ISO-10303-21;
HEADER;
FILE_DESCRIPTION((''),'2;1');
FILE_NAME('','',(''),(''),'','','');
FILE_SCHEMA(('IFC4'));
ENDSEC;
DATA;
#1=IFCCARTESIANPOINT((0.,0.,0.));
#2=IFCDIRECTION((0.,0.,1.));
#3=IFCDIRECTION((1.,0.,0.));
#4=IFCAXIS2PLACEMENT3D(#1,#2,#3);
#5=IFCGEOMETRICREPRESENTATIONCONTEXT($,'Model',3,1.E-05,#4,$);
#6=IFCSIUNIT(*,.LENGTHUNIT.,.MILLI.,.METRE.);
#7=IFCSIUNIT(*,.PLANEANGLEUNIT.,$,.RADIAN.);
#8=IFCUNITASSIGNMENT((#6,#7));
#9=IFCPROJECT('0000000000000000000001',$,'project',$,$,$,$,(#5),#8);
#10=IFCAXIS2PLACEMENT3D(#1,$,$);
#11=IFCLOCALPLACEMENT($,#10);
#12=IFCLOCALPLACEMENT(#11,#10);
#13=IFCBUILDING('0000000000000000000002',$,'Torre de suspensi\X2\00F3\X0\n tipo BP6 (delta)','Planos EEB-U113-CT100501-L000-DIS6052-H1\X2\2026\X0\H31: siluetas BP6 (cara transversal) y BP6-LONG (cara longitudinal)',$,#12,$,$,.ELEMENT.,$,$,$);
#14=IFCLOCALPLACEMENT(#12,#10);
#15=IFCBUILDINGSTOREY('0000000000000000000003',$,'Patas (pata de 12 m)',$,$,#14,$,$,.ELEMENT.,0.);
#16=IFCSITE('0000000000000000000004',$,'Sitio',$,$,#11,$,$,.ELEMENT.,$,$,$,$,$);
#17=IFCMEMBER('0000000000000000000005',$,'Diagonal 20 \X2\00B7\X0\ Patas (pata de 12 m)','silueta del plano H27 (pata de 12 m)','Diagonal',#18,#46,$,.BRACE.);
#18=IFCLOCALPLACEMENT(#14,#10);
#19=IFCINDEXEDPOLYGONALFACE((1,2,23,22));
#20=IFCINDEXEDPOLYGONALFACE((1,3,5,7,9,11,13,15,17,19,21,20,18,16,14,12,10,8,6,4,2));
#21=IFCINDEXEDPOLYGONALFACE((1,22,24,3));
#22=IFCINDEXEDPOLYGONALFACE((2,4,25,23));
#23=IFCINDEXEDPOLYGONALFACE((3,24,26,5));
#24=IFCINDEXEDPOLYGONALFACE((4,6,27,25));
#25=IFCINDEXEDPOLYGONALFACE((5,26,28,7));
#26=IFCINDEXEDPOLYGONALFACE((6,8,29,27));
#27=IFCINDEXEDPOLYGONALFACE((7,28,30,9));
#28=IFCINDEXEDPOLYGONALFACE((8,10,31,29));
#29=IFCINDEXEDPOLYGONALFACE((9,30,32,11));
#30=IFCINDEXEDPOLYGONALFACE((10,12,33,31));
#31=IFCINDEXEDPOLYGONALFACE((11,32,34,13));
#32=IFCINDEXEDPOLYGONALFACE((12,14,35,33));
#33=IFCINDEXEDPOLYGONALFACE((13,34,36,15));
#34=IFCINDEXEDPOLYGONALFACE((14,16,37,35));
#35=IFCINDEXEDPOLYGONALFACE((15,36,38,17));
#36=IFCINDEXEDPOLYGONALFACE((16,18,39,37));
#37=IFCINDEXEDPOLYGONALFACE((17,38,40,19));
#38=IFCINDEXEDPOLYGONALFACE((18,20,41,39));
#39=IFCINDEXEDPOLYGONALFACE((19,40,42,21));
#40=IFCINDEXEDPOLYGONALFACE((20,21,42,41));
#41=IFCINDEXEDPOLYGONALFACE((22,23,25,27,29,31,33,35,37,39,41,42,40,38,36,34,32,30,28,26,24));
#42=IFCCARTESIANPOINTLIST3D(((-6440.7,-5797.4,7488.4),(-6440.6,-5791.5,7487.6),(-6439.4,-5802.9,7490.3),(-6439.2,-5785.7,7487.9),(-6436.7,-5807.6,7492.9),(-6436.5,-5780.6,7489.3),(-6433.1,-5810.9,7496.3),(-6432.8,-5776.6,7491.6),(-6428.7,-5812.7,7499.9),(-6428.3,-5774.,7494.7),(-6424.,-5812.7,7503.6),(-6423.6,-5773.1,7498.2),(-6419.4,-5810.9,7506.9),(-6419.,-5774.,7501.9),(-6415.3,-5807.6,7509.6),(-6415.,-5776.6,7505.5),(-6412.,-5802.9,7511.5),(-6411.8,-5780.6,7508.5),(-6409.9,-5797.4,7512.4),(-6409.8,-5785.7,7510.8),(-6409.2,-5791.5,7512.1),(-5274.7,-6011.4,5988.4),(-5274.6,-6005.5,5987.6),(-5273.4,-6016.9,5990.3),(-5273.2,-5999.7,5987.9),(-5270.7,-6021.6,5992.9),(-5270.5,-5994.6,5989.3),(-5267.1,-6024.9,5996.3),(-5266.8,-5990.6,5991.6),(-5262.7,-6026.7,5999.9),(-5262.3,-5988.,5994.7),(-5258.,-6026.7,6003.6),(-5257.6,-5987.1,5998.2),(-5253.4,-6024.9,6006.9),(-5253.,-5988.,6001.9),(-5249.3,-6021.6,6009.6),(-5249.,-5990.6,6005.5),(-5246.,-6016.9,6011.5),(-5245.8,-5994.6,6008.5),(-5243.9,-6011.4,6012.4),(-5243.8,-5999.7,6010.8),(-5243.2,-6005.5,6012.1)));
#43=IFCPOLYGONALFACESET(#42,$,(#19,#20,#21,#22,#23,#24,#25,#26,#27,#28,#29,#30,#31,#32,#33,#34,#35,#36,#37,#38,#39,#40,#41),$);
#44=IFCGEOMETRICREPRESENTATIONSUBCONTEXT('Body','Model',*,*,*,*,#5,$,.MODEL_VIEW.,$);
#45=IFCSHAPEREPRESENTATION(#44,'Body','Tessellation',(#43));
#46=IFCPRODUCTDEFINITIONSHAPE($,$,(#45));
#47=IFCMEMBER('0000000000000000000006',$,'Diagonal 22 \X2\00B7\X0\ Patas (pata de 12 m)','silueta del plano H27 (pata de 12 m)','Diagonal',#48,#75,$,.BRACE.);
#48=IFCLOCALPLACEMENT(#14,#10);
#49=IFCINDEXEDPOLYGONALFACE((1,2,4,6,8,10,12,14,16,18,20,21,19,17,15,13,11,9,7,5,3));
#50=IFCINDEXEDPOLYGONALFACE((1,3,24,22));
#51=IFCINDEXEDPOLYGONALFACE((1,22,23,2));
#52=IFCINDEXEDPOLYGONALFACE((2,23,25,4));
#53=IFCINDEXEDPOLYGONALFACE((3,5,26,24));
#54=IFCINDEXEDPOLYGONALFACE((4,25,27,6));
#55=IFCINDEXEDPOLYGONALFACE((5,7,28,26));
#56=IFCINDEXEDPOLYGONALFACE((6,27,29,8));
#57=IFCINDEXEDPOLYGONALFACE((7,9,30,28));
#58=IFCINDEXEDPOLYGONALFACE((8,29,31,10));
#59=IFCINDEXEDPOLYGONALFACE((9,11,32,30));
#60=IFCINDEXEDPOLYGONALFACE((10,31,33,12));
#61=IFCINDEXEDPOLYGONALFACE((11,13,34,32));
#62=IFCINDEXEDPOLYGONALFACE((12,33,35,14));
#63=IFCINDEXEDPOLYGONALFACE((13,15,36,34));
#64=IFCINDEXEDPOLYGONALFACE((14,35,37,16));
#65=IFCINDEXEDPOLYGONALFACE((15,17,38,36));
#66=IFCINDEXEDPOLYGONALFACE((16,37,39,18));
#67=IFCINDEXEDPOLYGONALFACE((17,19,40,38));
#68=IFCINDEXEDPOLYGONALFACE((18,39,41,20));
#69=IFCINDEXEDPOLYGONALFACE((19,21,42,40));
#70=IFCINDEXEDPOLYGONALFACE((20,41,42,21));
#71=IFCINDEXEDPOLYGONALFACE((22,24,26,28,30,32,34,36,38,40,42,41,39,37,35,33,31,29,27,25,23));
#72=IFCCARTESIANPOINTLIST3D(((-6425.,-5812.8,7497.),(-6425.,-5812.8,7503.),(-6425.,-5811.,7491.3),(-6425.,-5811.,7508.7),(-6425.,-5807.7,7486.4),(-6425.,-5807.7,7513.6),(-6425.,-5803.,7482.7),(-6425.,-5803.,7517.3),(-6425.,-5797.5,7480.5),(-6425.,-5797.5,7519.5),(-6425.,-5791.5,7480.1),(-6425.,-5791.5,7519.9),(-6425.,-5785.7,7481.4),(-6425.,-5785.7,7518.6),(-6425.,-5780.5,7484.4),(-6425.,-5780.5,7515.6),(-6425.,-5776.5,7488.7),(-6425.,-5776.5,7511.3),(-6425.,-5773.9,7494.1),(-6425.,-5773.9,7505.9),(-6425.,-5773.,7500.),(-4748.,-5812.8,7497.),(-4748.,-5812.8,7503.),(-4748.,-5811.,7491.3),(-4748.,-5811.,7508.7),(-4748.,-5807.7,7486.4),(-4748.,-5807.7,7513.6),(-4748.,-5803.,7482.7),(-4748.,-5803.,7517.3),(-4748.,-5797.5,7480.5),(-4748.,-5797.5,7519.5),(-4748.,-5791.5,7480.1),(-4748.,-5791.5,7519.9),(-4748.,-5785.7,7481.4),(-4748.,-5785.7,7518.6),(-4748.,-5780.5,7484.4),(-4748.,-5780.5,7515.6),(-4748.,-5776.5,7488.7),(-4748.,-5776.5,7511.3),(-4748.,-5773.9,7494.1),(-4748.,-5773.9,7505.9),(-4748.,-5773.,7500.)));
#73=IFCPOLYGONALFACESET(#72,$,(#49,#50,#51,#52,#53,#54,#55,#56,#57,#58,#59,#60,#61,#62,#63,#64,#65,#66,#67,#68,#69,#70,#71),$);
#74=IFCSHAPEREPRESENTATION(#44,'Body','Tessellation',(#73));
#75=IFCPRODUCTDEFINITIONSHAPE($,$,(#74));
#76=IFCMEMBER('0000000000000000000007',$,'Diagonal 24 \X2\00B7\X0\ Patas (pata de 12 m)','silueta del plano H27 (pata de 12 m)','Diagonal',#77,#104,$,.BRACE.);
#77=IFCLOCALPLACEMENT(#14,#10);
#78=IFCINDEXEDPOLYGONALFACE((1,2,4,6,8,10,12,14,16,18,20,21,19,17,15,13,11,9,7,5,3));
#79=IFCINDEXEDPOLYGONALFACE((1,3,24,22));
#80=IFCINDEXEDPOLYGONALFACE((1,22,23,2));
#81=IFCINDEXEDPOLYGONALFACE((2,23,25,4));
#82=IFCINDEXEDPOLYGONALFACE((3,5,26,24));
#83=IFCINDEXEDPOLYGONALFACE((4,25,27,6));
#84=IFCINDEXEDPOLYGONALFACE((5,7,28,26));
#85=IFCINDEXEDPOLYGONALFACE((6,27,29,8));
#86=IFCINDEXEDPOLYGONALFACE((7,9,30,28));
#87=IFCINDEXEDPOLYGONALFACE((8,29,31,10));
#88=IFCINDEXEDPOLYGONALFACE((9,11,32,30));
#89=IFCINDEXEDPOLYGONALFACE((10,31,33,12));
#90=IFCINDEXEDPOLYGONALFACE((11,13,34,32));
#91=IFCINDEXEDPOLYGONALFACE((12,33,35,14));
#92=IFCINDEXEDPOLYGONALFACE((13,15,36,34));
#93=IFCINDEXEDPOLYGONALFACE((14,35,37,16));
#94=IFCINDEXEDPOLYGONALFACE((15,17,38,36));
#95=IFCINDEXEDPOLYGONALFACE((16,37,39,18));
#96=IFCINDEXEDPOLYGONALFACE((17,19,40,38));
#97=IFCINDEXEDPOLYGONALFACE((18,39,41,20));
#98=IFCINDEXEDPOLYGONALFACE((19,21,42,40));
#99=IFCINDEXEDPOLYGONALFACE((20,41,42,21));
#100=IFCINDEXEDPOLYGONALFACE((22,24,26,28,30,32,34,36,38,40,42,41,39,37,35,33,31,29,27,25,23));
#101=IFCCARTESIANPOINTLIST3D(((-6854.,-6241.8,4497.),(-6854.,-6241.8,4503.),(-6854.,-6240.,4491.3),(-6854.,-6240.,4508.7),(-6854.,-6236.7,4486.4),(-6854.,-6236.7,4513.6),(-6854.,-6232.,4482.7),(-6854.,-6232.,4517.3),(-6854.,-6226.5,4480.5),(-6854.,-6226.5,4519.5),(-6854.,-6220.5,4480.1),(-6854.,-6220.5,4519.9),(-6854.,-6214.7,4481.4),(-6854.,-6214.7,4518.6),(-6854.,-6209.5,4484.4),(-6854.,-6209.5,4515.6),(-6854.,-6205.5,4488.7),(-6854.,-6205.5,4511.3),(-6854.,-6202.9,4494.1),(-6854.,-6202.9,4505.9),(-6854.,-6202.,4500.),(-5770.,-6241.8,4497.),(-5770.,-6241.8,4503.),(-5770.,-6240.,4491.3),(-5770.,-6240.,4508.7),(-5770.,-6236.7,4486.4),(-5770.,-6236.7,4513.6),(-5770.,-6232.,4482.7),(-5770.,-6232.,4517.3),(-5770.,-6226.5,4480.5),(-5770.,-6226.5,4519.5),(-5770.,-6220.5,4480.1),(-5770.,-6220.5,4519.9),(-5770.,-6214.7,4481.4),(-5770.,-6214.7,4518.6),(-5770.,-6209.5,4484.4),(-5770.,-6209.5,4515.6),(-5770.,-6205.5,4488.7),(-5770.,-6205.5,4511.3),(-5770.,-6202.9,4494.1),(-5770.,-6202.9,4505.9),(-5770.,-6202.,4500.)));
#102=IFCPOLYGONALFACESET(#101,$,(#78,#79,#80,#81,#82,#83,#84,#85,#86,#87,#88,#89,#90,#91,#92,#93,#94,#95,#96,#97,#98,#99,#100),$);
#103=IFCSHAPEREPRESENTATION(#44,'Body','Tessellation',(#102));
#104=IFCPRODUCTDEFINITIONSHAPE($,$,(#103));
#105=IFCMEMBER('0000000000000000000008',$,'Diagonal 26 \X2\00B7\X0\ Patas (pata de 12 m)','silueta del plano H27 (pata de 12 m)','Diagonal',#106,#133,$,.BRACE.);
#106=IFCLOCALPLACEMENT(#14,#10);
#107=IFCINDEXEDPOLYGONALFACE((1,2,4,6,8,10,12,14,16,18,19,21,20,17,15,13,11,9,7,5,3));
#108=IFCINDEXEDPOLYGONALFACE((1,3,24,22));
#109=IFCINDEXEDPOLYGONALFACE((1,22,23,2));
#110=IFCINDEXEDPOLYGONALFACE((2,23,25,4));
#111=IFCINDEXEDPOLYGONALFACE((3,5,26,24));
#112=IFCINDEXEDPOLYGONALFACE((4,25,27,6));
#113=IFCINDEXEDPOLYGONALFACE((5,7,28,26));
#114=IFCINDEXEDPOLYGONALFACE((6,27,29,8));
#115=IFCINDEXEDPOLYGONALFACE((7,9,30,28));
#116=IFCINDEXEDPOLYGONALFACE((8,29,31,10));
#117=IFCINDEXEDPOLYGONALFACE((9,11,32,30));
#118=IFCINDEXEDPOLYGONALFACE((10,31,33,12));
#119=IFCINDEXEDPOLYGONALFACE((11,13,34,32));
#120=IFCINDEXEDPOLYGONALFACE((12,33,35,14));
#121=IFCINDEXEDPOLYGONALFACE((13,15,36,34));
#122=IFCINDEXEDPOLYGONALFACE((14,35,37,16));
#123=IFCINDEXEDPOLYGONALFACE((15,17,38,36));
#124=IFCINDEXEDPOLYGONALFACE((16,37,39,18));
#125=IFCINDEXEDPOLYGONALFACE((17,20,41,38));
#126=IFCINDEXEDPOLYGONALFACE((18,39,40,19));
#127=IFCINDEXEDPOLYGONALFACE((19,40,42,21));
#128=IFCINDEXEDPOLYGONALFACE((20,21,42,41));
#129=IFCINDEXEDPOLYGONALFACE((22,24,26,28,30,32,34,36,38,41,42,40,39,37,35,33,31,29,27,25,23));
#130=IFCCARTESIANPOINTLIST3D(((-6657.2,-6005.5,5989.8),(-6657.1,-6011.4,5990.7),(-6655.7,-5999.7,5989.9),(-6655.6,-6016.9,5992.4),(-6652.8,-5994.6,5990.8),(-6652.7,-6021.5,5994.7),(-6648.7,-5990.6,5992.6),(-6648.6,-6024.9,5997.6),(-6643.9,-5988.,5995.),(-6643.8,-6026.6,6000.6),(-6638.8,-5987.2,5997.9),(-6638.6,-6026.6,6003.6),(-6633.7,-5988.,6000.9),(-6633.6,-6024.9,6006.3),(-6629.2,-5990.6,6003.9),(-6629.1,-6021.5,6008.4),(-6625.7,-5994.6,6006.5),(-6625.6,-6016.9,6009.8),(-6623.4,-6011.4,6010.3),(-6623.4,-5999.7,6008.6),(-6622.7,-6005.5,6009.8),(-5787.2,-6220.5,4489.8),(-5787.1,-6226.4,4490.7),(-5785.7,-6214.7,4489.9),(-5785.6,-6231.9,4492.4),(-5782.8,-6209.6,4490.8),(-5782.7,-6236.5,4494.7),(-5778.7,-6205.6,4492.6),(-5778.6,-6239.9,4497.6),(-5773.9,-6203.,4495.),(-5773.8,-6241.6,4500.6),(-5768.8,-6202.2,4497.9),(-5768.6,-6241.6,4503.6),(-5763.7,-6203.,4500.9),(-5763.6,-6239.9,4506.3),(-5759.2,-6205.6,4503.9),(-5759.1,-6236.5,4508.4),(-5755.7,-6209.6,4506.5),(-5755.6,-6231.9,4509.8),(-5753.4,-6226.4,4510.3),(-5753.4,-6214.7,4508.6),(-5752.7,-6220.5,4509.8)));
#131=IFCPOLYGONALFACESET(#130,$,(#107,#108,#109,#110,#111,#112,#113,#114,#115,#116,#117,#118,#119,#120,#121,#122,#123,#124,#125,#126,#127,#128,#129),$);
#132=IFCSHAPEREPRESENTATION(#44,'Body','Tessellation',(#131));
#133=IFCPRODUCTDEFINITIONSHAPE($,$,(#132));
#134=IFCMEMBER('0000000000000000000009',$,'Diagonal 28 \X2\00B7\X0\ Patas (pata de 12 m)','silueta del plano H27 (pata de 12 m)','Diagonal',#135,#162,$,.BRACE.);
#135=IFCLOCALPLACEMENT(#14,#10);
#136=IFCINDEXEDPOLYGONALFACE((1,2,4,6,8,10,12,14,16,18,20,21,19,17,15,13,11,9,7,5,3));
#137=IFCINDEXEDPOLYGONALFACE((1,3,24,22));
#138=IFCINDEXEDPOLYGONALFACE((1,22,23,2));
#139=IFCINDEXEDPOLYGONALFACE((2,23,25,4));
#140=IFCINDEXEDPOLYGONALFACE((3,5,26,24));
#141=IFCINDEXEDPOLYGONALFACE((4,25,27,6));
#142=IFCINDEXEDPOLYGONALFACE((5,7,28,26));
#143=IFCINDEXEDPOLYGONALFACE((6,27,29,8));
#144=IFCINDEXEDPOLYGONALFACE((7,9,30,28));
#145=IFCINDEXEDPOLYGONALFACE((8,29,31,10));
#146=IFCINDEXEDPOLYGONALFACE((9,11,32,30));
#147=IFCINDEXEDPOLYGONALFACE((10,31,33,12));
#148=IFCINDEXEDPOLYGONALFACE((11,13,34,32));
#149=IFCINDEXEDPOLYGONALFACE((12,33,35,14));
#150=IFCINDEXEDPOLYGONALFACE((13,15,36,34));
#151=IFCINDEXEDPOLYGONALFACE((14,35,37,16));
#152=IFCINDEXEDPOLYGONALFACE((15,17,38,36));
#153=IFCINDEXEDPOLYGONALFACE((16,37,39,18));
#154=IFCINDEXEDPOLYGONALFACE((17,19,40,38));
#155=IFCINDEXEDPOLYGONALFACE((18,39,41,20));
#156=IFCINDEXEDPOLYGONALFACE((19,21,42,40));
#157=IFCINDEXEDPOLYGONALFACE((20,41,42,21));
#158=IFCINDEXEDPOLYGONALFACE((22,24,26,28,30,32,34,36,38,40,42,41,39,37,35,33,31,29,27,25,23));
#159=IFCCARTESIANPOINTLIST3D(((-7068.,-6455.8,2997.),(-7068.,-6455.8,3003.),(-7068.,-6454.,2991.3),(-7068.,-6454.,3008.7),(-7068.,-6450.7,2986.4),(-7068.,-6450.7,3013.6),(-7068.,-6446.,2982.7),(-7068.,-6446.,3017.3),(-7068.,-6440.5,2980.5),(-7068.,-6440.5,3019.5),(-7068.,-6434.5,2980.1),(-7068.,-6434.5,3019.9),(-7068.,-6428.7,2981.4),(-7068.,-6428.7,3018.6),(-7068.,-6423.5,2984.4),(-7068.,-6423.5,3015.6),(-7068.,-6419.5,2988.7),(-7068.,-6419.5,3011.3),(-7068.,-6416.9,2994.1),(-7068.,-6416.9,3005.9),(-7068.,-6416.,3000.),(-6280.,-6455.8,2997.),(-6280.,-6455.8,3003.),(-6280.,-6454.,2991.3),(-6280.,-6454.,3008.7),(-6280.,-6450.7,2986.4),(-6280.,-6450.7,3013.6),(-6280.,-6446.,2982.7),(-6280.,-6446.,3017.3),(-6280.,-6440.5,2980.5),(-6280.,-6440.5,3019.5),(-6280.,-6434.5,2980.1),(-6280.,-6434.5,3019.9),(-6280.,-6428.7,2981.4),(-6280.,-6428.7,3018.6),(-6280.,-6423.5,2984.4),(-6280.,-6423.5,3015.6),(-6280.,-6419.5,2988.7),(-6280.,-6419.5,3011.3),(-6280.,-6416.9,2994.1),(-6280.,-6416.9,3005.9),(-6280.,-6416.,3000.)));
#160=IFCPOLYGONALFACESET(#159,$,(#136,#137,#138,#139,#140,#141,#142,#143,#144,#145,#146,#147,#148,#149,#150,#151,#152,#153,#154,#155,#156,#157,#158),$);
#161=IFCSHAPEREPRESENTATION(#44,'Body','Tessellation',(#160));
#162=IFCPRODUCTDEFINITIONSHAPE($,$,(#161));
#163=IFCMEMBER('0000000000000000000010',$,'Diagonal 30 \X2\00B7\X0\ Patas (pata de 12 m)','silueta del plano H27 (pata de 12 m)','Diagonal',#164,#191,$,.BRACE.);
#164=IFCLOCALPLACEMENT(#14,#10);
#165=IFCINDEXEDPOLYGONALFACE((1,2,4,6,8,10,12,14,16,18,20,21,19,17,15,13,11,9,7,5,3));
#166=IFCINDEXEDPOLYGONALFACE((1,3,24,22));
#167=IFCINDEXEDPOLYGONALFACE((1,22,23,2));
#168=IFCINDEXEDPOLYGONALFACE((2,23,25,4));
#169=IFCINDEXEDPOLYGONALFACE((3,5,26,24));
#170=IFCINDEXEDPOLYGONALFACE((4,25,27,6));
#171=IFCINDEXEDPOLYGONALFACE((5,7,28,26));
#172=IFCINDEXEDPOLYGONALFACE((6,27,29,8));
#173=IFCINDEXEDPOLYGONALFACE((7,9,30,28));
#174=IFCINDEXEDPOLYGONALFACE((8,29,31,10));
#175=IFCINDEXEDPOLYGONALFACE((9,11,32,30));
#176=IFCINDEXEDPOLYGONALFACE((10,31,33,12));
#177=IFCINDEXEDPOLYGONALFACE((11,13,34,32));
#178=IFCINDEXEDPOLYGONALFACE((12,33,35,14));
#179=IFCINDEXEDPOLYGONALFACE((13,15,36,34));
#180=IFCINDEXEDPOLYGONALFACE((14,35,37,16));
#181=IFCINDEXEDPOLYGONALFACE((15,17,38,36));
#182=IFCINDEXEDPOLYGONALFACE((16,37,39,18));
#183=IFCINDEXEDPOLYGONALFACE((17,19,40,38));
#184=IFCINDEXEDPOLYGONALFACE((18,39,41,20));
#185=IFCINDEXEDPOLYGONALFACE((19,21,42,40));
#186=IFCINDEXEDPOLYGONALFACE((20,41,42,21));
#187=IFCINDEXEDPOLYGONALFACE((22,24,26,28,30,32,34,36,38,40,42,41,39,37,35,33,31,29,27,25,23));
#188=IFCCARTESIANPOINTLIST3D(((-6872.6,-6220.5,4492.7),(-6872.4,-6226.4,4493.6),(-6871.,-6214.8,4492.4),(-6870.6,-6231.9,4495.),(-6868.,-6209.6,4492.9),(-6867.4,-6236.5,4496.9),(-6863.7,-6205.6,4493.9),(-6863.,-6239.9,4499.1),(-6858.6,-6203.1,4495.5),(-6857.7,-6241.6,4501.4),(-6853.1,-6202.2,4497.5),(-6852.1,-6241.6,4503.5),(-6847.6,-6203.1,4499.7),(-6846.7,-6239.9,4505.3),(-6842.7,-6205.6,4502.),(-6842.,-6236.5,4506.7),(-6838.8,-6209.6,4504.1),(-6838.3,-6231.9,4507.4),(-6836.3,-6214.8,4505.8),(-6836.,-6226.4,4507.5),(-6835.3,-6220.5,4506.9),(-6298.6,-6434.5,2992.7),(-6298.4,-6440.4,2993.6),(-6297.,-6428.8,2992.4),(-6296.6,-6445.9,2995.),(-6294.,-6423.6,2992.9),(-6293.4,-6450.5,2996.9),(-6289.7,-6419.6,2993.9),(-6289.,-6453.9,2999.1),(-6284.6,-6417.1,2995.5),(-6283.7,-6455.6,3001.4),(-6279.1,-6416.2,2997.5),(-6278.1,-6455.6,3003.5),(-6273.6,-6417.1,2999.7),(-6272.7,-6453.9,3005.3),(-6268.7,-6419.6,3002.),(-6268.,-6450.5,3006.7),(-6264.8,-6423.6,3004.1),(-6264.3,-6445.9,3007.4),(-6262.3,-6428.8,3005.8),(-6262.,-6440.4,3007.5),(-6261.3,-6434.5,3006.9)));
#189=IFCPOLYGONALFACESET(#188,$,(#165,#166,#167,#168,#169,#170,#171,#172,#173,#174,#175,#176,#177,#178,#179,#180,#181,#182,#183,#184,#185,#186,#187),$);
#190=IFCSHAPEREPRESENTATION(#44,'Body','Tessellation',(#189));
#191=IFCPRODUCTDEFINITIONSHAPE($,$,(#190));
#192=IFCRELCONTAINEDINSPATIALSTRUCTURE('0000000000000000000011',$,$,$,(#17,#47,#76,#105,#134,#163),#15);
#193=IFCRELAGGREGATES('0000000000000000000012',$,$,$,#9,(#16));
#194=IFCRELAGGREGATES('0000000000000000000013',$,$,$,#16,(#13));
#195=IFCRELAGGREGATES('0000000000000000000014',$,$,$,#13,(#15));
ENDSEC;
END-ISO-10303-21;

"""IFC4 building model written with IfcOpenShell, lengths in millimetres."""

from ifc_helpers import new_model, si_unit, frame, origin, origin_with_axes, place, context, subcontext, project, spatial, circle, extrude, element, save


model = new_model("IFC4")

# Units and contexts
model_context = context("Model", 3, precision=1e-05, world=origin_with_axes())
body_context = subcontext(model_context, "Body", "Model", "MODEL_VIEW")
ifc_project = project(units=[si_unit("LENGTHUNIT", "METRE", prefix="MILLI"), si_unit("PLANEANGLEUNIT", "RADIAN")], contexts=[model_context])

# Site, building, storey
site_placement = place(None, origin())
site = spatial("IfcSite", under=ifc_project, at=site_placement, Name="Sitio", CompositionType="ELEMENT")
building_placement = place(site_placement, origin())
building = spatial("IfcBuilding", under=site, at=building_placement, Name="Torre de suspensión tipo BP6 (delta)", Description="Planos EEB-U113-CT100501-L000-DIS6052-H1…H31: siluetas BP6 (cara transversal) y BP6-LONG (cara longitudinal)", CompositionType="ELEMENT")
storey_placement = place(building_placement, origin())
storey = spatial("IfcBuildingStorey", under=building, at=storey_placement, Name="Patas (pata de 12 m)", CompositionType="ELEMENT", Elevation=0.0)

# Members
member_1_placement = place(storey_placement, frame((-5259.0, -6007.0, 6000.0), z_axis=(-0.609865, 0.111931, 0.784561), x_axis=(0.068694, 0.993716, -0.088372)))
element("IfcMember", 1, at=member_1_placement, inside=storey, Name="Diagonal 20 · Patas (pata de 12 m)", Description="silueta del plano H27 (pata de 12 m)", ObjectType="Diagonal", PredefinedType="BRACE", context=body_context, shape_type="SweptSolid", body=[
    extrude(circle(Radius=20.0), None, (0.0, 0.0, 1.0), 1911.9),
])
member_2_placement = place(storey_placement, frame((-6425.0, -5793.0, 7500.0), z_axis=(1.0, 0.0, 0.0), x_axis=(0.0, 1.0, 0.0)))
element("IfcMember", 2, at=member_2_placement, inside=storey, Name="Diagonal 22 · Patas (pata de 12 m)", Description="silueta del plano H27 (pata de 12 m)", ObjectType="Diagonal", PredefinedType="BRACE", context=body_context, shape_type="SweptSolid", body=[
    extrude(circle(Radius=20.0), None, (0.0, 0.0, 1.0), 1677.0),
])
member_3_placement = place(storey_placement, frame((-6854.0, -6222.0, 4500.0), z_axis=(1.0, 0.0, 0.0), x_axis=(0.0, 1.0, 0.0)))
element("IfcMember", 3, at=member_3_placement, inside=storey, Name="Diagonal 24 · Patas (pata de 12 m)", Description="silueta del plano H27 (pata de 12 m)", ObjectType="Diagonal", PredefinedType="BRACE", context=body_context, shape_type="SweptSolid", body=[
    extrude(circle(Radius=20.0), None, (0.0, 0.0, 1.0), 1084.0),
])
member_4_placement = place(storey_placement, frame((-5770.0, -6222.0, 4500.0), z_axis=(-0.497906, 0.123046, 0.858458), x_axis=(0.061734, 0.992401, -0.106438)))
element("IfcMember", 4, at=member_4_placement, inside=storey, Name="Diagonal 26 · Patas (pata de 12 m)", Description="silueta del plano H27 (pata de 12 m)", ObjectType="Diagonal", PredefinedType="BRACE", context=body_context, shape_type="SweptSolid", body=[
    extrude(circle(Radius=20.0), None, (0.0, 0.0, 1.0), 1747.3),
])
member_5_placement = place(storey_placement, frame((-7068.0, -6436.0, 3000.0), z_axis=(1.0, 0.0, 0.0), x_axis=(0.0, 1.0, 0.0)))
element("IfcMember", 5, at=member_5_placement, inside=storey, Name="Diagonal 28 · Patas (pata de 12 m)", Description="silueta del plano H27 (pata de 12 m)", ObjectType="Diagonal", PredefinedType="BRACE", context=body_context, shape_type="SweptSolid", body=[
    extrude(circle(Radius=20.0), None, (0.0, 0.0, 1.0), 788.0),
])
member_6_placement = place(storey_placement, frame((-6280.0, -6436.0, 3000.0), z_axis=(-0.354262, 0.132077, 0.925772), x_axis=(0.047203, 0.991239, -0.123354)))
element("IfcMember", 6, at=member_6_placement, inside=storey, Name="Diagonal 30 · Patas (pata de 12 m)", Description="silueta del plano H27 (pata de 12 m)", ObjectType="Diagonal", PredefinedType="BRACE", context=body_context, shape_type="SweptSolid", body=[
    extrude(circle(Radius=20.0), None, (0.0, 0.0, 1.0), 1620.3),
])

save(model, "model.ifc")
